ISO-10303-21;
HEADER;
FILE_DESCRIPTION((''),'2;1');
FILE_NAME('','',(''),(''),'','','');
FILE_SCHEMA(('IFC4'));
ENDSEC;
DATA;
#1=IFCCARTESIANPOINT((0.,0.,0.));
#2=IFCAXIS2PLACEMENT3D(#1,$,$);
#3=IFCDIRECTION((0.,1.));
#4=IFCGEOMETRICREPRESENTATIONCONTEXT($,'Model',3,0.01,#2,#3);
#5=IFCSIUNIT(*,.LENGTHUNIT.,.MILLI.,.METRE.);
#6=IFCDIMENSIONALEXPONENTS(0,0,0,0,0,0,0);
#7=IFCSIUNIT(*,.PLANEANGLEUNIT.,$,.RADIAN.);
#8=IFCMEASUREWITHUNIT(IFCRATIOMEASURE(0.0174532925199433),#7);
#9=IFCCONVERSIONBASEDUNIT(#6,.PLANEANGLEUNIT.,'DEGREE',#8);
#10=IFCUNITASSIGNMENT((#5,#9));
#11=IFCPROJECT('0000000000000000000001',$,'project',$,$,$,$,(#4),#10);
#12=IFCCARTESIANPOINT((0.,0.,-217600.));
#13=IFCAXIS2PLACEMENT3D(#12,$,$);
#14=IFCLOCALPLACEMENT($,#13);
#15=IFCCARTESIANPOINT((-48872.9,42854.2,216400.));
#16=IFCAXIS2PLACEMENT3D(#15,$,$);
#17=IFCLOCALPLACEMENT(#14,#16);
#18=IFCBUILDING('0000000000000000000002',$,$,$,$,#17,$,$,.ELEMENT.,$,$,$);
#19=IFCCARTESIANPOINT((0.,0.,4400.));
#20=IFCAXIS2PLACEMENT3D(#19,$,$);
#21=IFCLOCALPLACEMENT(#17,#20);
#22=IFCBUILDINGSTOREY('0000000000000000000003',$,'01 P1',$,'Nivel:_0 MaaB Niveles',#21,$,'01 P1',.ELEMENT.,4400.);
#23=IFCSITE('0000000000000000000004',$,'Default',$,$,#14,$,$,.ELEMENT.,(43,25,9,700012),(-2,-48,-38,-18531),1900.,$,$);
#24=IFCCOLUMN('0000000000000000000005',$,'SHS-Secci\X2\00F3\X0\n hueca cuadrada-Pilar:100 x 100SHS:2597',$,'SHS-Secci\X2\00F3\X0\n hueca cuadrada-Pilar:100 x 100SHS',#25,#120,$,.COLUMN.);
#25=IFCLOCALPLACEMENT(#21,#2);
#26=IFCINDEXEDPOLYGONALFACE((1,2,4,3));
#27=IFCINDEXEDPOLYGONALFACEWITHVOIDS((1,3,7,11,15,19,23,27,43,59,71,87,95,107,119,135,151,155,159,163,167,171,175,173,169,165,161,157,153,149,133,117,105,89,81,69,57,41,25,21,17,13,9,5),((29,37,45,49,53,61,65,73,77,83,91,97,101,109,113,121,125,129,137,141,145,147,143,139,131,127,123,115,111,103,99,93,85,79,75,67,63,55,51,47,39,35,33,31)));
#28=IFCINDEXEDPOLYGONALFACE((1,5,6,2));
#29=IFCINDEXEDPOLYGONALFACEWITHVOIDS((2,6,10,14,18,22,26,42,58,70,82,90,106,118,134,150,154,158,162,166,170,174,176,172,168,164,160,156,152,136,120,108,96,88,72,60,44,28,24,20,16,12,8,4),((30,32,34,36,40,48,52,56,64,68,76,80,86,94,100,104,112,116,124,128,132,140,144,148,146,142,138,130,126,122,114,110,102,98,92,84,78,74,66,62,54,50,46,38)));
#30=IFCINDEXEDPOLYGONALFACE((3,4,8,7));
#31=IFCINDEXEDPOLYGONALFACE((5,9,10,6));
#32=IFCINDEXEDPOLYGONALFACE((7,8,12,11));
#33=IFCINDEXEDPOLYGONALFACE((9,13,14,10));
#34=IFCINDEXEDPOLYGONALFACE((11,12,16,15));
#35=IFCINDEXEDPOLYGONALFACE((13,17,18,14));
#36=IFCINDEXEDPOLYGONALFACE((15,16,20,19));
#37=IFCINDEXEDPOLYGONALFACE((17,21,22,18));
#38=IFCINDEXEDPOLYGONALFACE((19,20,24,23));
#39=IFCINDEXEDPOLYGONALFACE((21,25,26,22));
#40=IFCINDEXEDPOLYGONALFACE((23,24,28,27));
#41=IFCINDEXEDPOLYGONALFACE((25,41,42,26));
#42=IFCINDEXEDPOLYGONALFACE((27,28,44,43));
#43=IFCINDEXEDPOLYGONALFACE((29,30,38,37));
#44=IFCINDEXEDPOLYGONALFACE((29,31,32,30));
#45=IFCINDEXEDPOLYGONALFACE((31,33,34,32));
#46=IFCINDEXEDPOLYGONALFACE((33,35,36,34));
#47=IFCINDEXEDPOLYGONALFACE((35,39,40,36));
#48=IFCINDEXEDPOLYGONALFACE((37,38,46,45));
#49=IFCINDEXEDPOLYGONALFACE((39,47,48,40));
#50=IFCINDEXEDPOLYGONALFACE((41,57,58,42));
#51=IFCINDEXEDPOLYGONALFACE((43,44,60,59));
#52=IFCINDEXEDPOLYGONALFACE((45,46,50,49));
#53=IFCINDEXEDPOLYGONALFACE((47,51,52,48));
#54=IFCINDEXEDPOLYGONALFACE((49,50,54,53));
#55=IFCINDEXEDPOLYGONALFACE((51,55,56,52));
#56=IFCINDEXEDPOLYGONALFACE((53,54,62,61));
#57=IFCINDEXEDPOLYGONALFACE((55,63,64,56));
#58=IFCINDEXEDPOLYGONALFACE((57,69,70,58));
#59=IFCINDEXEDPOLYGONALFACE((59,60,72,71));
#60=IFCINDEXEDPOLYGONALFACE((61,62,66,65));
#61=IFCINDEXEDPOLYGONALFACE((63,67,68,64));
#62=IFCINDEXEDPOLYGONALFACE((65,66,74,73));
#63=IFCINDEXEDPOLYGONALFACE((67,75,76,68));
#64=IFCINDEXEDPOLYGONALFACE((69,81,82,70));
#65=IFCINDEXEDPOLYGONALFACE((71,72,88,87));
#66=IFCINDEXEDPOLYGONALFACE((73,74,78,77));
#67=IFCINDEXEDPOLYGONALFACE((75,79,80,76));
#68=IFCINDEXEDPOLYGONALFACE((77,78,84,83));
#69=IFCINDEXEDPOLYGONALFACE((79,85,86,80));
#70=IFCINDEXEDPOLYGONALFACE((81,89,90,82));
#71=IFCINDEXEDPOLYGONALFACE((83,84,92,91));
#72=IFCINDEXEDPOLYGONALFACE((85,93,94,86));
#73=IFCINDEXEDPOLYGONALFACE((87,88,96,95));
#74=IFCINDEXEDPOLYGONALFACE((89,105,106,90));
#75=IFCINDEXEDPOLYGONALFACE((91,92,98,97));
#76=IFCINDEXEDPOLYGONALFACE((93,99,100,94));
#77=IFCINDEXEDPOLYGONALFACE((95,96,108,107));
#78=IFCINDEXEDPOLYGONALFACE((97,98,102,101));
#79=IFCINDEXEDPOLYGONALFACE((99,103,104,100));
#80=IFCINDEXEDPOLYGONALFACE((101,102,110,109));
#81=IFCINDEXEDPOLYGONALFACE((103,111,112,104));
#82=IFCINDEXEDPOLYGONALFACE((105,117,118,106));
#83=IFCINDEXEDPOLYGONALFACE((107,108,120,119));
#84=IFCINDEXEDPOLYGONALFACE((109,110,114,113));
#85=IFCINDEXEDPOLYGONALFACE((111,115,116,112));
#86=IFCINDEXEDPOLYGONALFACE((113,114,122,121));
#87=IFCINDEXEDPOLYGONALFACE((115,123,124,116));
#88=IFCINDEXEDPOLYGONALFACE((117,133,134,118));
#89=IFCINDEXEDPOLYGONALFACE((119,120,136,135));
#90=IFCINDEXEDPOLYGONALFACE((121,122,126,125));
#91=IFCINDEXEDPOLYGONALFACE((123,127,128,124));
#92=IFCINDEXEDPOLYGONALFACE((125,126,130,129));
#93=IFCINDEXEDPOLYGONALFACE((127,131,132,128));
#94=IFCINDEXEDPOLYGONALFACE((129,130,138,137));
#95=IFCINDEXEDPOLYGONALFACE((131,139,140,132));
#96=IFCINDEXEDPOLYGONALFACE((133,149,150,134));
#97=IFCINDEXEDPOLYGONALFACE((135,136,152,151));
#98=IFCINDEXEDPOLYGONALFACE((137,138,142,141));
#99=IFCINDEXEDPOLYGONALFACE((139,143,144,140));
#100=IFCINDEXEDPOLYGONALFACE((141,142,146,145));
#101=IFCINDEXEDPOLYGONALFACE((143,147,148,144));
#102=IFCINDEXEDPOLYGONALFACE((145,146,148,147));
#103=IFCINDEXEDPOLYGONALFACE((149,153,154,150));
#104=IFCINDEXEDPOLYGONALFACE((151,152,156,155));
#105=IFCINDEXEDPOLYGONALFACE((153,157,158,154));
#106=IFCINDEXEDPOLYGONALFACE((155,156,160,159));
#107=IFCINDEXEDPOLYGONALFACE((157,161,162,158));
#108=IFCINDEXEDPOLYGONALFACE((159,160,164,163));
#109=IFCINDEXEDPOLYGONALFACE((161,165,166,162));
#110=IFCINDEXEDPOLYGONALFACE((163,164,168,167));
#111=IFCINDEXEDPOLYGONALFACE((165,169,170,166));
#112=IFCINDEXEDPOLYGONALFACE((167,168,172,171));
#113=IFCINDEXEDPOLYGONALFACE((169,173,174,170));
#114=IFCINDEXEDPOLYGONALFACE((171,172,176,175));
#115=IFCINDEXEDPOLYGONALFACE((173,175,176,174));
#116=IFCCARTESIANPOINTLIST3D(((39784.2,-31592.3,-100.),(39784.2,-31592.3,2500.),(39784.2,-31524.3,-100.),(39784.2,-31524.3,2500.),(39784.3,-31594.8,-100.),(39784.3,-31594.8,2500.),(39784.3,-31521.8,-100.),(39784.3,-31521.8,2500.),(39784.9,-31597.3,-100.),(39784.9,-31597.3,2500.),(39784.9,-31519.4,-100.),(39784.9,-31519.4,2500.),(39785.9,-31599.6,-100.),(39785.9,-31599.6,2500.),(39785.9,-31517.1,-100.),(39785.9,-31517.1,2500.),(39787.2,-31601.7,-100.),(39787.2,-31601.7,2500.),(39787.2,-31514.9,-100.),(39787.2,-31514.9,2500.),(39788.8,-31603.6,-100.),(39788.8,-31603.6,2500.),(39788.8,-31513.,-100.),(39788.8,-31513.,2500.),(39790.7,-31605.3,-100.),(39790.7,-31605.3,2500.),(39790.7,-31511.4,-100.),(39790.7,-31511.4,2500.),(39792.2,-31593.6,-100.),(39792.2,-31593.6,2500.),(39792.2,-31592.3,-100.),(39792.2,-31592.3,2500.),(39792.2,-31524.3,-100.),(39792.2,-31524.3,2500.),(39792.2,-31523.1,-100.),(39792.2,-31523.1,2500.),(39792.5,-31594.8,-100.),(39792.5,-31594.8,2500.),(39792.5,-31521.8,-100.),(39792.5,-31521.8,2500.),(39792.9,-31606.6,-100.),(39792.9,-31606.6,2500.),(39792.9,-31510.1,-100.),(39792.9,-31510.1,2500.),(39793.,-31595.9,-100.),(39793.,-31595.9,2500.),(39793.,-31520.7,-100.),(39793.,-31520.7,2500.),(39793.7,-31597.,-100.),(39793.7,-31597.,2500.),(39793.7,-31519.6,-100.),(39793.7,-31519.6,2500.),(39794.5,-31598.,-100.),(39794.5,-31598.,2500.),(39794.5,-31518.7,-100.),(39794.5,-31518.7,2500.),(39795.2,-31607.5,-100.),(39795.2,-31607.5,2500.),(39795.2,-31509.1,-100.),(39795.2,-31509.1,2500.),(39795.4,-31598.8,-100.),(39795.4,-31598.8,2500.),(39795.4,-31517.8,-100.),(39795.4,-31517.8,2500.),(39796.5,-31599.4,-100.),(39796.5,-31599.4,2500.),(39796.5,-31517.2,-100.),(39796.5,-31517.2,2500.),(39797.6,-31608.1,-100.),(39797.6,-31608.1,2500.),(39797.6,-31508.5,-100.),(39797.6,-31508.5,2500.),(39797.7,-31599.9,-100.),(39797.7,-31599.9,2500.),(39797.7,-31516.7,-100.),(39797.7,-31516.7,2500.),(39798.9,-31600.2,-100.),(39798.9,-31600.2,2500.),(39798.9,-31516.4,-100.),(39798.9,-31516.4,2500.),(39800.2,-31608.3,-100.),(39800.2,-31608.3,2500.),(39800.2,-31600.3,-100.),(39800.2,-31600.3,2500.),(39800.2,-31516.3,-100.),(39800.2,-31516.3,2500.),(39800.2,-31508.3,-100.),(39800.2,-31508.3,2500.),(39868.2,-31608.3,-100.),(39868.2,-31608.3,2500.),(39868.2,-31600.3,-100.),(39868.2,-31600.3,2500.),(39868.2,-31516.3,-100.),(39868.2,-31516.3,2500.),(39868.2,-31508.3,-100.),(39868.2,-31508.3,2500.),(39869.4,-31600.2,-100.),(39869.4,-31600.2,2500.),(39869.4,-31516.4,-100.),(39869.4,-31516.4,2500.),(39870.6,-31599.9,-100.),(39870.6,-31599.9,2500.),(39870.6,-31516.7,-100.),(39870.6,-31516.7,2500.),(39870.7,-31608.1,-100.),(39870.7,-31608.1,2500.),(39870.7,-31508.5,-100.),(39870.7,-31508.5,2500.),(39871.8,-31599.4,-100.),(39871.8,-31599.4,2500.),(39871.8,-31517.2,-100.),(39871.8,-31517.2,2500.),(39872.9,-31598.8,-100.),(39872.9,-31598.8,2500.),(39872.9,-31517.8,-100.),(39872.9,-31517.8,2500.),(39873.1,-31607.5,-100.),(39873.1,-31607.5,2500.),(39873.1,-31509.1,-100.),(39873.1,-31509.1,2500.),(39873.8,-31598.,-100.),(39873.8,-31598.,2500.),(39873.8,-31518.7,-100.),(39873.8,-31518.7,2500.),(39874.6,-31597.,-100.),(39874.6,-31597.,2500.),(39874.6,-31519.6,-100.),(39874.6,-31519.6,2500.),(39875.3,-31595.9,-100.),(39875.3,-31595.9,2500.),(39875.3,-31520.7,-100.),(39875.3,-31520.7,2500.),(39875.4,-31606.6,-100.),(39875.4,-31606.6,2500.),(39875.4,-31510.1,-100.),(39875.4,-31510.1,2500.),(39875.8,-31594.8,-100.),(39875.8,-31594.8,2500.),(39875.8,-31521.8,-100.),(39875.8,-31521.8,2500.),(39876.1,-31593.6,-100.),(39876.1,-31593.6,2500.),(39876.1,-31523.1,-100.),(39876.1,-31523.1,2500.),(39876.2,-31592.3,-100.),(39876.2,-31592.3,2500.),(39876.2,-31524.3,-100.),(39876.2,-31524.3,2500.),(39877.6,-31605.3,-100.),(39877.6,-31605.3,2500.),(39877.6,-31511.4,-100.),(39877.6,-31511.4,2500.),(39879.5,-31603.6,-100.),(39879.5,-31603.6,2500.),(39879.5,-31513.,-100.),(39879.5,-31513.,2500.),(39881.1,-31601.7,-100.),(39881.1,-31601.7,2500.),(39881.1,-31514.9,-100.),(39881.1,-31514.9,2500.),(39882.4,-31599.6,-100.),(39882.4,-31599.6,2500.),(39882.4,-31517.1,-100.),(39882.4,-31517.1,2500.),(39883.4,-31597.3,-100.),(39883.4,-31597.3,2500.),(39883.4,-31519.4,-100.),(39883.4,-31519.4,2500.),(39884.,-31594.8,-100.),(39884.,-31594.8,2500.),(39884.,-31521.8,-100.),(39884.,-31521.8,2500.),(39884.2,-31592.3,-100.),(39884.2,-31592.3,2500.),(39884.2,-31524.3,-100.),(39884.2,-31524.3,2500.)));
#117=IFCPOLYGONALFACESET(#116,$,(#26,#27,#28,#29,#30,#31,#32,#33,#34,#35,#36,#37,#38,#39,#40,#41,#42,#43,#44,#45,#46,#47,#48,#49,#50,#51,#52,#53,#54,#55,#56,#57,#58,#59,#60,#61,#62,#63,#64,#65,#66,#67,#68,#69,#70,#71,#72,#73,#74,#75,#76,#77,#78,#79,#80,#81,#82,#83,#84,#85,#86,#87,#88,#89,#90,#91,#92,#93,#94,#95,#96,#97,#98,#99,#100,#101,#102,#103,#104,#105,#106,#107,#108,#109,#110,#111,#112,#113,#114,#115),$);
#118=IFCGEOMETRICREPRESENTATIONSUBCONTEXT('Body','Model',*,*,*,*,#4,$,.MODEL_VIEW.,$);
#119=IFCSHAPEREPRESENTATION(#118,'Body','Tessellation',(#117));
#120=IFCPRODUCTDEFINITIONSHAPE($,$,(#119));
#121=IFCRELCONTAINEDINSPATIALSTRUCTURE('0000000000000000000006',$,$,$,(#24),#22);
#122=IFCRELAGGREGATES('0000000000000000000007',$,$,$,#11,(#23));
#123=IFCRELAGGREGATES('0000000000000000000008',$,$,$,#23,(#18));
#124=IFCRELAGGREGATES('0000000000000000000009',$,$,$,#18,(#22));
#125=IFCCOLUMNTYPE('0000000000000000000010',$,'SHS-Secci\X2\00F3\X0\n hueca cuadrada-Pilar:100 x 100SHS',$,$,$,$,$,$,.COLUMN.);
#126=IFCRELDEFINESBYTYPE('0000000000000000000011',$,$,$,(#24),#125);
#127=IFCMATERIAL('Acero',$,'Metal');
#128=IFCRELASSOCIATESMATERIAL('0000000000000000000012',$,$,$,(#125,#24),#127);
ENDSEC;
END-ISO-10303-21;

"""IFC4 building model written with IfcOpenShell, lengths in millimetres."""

from ifc_helpers import new_model, entity, si_unit, converted_unit, direction, frame, origin, place, context, subcontext, project, spatial, indexed_curve, outline, extrude, source, transform, mapped, material, type_object, type_shapes, element, save


model = new_model("IFC4")

# Units and contexts
model_context = context("Model", 3, precision=0.01, world=origin(), true_north=direction((0.0, 1.0)))
body_context = subcontext(model_context, "Body", "Model", "MODEL_VIEW")
ifc_project = project(units=[si_unit("LENGTHUNIT", "METRE", prefix="MILLI"), converted_unit("PLANEANGLEUNIT", "DEGREE", entity("IfcRatioMeasure", 0.0174532925199433), si_unit("PLANEANGLEUNIT", "RADIAN"), dimensions=[0, 0, 0, 0, 0, 0, 0])], contexts=[model_context])

# Site, building, storey
site_placement = place(None, frame((0.0, 0.0, -217600.0)))
site = spatial("IfcSite", under=ifc_project, at=site_placement, Name="Default", CompositionType="ELEMENT", RefLatitude=(43, 25, 9, 700012), RefLongitude=(-2, -48, -38, -18531), RefElevation=1900.0)
building_placement = place(site_placement, frame((-48872.9, 42854.2, 216400.0)))
building = spatial("IfcBuilding", under=site, at=building_placement, CompositionType="ELEMENT")
storey_placement = place(building_placement, frame((0.0, 0.0, 4400.0)))
storey = spatial("IfcBuildingStorey", under=building, at=storey_placement, Name="01 P1", ObjectType="Nivel:_0 MaaB Niveles", LongName="01 P1", CompositionType="ELEMENT", Elevation=4400.0)

# Column
ifc_material_1 = material(Name="Acero", Category="Metal")
column_type_1 = type_object("IfcColumnType", Name="SHS-Sección hueca cuadrada-Pilar:100 x 100SHS", PredefinedType="COLUMN", material=ifc_material_1)
shared_shape_1 = source(origin(), body_context, "Body", "SweptSolid", [
    extrude(outline(indexed_curve([(-34.0, -50.0), (34.0, -50.0), (36.5, -49.8), (38.9, -49.2), (41.3, -48.3), (43.4, -46.9), (45.3, -45.3), (46.9, -43.4), (48.3, -41.3), (49.2, -38.9), (49.8, -36.5), (50.0, -34.0), (50.0, 34.0), (49.8, 36.5), (49.2, 38.9), (48.3, 41.3), (46.9, 43.4), (45.3, 45.3), (43.4, 46.9), (41.3, 48.3), (38.9, 49.2), (36.5, 49.8), (34.0, 50.0), (-34.0, 50.0), (-36.5, 49.8), (-38.9, 49.2), (-41.3, 48.3), (-43.4, 46.9), (-45.3, 45.3), (-46.9, 43.4), (-48.3, 41.3), (-49.2, 38.9), (-49.8, 36.5), (-50.0, 34.0), (-50.0, -34.0), (-49.8, -36.5), (-49.2, -38.9), (-48.3, -41.3), (-46.9, -43.4), (-45.3, -45.3), (-43.4, -46.9), (-41.3, -48.3), (-38.9, -49.2), (-36.5, -49.8), (-34.0, -50.0)], self_intersect=False), holes=[indexed_curve([(-34.0, -42.0), (-35.3, -41.9), (-36.5, -41.6), (-37.6, -41.1), (-38.7, -40.5), (-39.7, -39.7), (-40.5, -38.7), (-41.1, -37.6), (-41.6, -36.5), (-41.9, -35.3), (-42.0, -34.0), (-42.0, 34.0), (-41.9, 35.3), (-41.6, 36.5), (-41.1, 37.6), (-40.5, 38.7), (-39.7, 39.7), (-38.7, 40.5), (-37.6, 41.1), (-36.5, 41.6), (-35.3, 41.9), (-34.0, 42.0), (34.0, 42.0), (35.3, 41.9), (36.5, 41.6), (37.6, 41.1), (38.7, 40.5), (39.7, 39.7), (40.5, 38.7), (41.1, 37.6), (41.6, 36.5), (41.9, 35.3), (42.0, 34.0), (42.0, -34.0), (41.9, -35.3), (41.6, -36.5), (41.1, -37.6), (40.5, -38.7), (39.7, -39.7), (38.7, -40.5), (37.6, -41.1), (36.5, -41.6), (35.3, -41.9), (34.0, -42.0), (-34.0, -42.0)], self_intersect=False)]), frame((0.0, 0.0, 4300.0), z_axis=(0.0, 0.0, 1.0), x_axis=(-1.0, 0.0, 0.0)), (0.0, 0.0, 1.0), 2600.0),
])
type_shapes(column_type_1, [shared_shape_1])
column_1_placement = place(storey_placement, frame((39834.2, -31558.3, -4400.0), z_axis=(0.0, 0.0, 1.0), x_axis=(0.0, -1.0, 0.0)))
element("IfcColumn", 1, at=column_1_placement, inside=storey, type_object=column_type_1, material=ifc_material_1, Name="SHS-Sección hueca cuadrada-Pilar:100 x 100SHS:2597", ObjectType="SHS-Sección hueca cuadrada-Pilar:100 x 100SHS", PredefinedType="COLUMN", context=body_context, shape_type="MappedRepresentation", body=[
    mapped(shared_shape_1, transform((0.0, 0.0, 0.0), scale=1.0)),
])

save(model, "model.ifc")
